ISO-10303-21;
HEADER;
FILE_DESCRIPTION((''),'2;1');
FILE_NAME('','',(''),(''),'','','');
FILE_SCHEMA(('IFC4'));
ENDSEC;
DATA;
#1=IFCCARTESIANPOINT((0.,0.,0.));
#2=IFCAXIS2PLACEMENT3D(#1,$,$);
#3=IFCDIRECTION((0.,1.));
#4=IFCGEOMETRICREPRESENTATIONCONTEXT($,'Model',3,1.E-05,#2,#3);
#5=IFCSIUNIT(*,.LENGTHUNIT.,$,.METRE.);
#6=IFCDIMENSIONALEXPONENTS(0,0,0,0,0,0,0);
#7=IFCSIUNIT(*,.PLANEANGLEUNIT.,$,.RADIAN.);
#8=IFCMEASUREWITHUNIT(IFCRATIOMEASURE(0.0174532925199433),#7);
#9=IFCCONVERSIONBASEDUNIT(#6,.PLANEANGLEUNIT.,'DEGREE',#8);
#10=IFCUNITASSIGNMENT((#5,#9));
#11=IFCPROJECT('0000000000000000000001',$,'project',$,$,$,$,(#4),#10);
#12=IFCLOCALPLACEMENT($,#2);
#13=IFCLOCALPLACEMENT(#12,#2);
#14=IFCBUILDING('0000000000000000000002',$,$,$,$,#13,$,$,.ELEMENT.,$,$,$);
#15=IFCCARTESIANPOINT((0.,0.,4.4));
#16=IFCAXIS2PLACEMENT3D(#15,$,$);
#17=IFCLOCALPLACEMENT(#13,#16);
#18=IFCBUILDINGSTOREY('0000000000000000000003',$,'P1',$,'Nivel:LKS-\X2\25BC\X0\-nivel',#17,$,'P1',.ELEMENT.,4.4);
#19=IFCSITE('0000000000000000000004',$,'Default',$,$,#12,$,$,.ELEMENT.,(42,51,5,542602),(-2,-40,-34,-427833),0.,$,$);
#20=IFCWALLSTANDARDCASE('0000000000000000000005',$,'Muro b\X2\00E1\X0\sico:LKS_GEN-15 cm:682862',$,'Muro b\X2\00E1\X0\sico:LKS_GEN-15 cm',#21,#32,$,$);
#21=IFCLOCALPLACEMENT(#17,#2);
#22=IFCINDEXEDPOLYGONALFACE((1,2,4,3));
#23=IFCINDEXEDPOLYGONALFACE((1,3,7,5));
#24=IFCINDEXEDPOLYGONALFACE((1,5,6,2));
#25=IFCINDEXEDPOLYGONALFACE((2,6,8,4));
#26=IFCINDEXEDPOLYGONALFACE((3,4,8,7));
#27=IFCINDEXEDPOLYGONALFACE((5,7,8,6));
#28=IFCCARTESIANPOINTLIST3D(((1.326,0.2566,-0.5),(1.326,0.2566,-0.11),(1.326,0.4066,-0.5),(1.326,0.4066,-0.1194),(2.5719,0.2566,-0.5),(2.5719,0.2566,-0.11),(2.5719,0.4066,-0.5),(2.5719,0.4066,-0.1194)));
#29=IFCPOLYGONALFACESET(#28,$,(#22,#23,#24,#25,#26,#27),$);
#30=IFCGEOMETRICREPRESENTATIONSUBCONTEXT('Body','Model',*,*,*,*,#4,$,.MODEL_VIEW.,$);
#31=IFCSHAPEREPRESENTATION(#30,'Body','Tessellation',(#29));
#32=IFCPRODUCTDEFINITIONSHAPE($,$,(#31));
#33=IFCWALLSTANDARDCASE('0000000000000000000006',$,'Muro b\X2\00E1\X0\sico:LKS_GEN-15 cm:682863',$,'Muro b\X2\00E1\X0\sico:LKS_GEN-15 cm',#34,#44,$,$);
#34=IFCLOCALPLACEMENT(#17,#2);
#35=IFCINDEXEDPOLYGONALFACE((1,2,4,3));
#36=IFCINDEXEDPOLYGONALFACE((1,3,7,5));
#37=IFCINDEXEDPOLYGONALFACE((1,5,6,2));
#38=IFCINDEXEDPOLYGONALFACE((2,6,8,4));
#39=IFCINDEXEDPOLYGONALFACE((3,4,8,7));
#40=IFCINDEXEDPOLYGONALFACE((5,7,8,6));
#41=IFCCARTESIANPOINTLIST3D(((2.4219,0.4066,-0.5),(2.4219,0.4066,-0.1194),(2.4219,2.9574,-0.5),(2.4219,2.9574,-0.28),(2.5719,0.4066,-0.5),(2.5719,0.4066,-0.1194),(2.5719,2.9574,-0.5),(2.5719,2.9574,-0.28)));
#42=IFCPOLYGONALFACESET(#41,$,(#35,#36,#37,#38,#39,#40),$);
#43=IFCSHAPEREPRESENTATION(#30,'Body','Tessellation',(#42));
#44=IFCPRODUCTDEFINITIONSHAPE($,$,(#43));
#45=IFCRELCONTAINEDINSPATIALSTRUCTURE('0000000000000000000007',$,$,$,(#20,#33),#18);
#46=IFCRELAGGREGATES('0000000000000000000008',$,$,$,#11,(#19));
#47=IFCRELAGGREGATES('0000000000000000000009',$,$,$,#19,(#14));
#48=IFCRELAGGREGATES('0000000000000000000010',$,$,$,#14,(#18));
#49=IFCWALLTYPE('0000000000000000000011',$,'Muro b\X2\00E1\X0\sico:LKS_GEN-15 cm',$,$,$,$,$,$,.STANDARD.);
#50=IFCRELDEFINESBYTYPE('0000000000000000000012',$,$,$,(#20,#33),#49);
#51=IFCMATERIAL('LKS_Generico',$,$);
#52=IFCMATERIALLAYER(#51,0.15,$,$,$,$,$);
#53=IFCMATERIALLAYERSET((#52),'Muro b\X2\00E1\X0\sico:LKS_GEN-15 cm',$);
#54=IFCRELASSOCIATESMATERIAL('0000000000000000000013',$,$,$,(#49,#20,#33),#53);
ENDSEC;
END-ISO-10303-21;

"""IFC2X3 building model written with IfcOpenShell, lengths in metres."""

from ifc_helpers import new_model, entity, si_unit, converted_unit, direction, frame, frame_2d, origin, place, context, subcontext, project, spatial, polyline, rectangle, extrude, clip, bounded_halfspace, material, layer, layer_set, layer_usage, type_object, element, save


model = new_model("IFC2X3")

# Units and contexts
model_context = context("Model", 3, precision=1e-05, world=origin(), true_north=direction((0.0, 1.0)))
body_context = subcontext(model_context, "Body", "Model", "MODEL_VIEW")
ifc_project = project(units=[si_unit("LENGTHUNIT", "METRE"), converted_unit("PLANEANGLEUNIT", "DEGREE", entity("IfcRatioMeasure", 0.0174532925199433), si_unit("PLANEANGLEUNIT", "RADIAN"), dimensions=[0, 0, 0, 0, 0, 0, 0])], contexts=[model_context])

# Site, building, storey
site_placement = place(None, origin())
site = spatial("IfcSite", under=ifc_project, at=site_placement, Name="Default", CompositionType="ELEMENT", RefLatitude=(42, 51, 5, 542602), RefLongitude=(-2, -40, -34, -427833), RefElevation=0.0)
building_placement = place(site_placement, origin())
building = spatial("IfcBuilding", under=site, at=building_placement, CompositionType="ELEMENT")
storey_placement = place(building_placement, frame((0.0, 0.0, 4.4)))
storey = spatial("IfcBuildingStorey", under=building, at=storey_placement, Name="P1", ObjectType="Nivel:LKS-▼-nivel", LongName="P1", CompositionType="ELEMENT", Elevation=4.4)

# Shared definitions
ifc_material_1 = material(Name="LKS_Generico")

# Walls
ifc_layer_1 = layer(ifc_material_1, 0.15)
ifc_layer_set_1 = layer_set([ifc_layer_1], Name="Muro básico:LKS_GEN-15 cm")
wall_type_1 = type_object("IfcWallType", Name="Muro básico:LKS_GEN-15 cm", PredefinedType="STANDARD", material=ifc_layer_set_1)
ifc_layer_usage_1 = layer_usage(ifc_layer_set_1, "AXIS2", "NEGATIVE", 0.075)
wall_1_placement = place(storey_placement, frame((2.5719, 0.3316, -0.5), z_axis=(0.0, 0.0, 1.0), x_axis=(-1.0, 0.0, 0.0)))
element("IfcWallStandardCase", 1, at=wall_1_placement, inside=storey, type_object=wall_type_1, material=ifc_layer_usage_1, Name="Muro básico:LKS_GEN-15 cm:682862", ObjectType="Muro básico:LKS_GEN-15 cm", context=body_context, shape_type="Clipping", body=[
    clip(extrude(rectangle(XDim=1.2459, YDim=0.15, at=frame_2d((0.6229, 0.0), x_axis=(-1.0, 0.0))), origin(), (0.0, 0.0, 1.0), 0.39), bounded_halfspace(frame((0.0, -0.075, 0.3806), z_axis=(0.0, -0.06282, 0.998025), x_axis=(0.0, -0.998025, -0.06282)), False, frame((0.0, -0.075, 0.3806)), polyline([(0.0, 0.0), (0.15, 0.0), (1.2459, 0.0), (1.2459, 0.15), (0.0, 0.15), (0.0, 0.0)]))),
])
ifc_layer_usage_2 = layer_usage(ifc_layer_set_1, "AXIS2", "NEGATIVE", 0.075)
wall_2_placement = place(storey_placement, frame((2.4969, 2.9574, -0.5), z_axis=(0.0, 0.0, 1.0), x_axis=(0.0, -1.0, 0.0)))
element("IfcWallStandardCase", 2, at=wall_2_placement, inside=storey, type_object=wall_type_1, material=ifc_layer_usage_2, Name="Muro básico:LKS_GEN-15 cm:682863", ObjectType="Muro básico:LKS_GEN-15 cm", context=body_context, shape_type="Clipping", body=[
    clip(extrude(rectangle(XDim=2.5508, YDim=0.15, at=frame_2d((1.2754, 0.0), x_axis=(-1.0, 0.0))), origin(), (0.0, 0.0, 1.0), 0.3806), bounded_halfspace(frame((0.0, -0.075, 0.22), z_axis=(-0.06282, 0.0, 0.998025), x_axis=(-0.998025, 0.0, -0.06282)), False, frame((0.0, -0.075, 0.22)), polyline([(0.0, 0.0), (0.15, 0.0), (2.5508, 0.0), (2.5508, 0.15), (0.0, 0.15), (0.0, 0.0)]))),
])

save(model, "model.ifc")
